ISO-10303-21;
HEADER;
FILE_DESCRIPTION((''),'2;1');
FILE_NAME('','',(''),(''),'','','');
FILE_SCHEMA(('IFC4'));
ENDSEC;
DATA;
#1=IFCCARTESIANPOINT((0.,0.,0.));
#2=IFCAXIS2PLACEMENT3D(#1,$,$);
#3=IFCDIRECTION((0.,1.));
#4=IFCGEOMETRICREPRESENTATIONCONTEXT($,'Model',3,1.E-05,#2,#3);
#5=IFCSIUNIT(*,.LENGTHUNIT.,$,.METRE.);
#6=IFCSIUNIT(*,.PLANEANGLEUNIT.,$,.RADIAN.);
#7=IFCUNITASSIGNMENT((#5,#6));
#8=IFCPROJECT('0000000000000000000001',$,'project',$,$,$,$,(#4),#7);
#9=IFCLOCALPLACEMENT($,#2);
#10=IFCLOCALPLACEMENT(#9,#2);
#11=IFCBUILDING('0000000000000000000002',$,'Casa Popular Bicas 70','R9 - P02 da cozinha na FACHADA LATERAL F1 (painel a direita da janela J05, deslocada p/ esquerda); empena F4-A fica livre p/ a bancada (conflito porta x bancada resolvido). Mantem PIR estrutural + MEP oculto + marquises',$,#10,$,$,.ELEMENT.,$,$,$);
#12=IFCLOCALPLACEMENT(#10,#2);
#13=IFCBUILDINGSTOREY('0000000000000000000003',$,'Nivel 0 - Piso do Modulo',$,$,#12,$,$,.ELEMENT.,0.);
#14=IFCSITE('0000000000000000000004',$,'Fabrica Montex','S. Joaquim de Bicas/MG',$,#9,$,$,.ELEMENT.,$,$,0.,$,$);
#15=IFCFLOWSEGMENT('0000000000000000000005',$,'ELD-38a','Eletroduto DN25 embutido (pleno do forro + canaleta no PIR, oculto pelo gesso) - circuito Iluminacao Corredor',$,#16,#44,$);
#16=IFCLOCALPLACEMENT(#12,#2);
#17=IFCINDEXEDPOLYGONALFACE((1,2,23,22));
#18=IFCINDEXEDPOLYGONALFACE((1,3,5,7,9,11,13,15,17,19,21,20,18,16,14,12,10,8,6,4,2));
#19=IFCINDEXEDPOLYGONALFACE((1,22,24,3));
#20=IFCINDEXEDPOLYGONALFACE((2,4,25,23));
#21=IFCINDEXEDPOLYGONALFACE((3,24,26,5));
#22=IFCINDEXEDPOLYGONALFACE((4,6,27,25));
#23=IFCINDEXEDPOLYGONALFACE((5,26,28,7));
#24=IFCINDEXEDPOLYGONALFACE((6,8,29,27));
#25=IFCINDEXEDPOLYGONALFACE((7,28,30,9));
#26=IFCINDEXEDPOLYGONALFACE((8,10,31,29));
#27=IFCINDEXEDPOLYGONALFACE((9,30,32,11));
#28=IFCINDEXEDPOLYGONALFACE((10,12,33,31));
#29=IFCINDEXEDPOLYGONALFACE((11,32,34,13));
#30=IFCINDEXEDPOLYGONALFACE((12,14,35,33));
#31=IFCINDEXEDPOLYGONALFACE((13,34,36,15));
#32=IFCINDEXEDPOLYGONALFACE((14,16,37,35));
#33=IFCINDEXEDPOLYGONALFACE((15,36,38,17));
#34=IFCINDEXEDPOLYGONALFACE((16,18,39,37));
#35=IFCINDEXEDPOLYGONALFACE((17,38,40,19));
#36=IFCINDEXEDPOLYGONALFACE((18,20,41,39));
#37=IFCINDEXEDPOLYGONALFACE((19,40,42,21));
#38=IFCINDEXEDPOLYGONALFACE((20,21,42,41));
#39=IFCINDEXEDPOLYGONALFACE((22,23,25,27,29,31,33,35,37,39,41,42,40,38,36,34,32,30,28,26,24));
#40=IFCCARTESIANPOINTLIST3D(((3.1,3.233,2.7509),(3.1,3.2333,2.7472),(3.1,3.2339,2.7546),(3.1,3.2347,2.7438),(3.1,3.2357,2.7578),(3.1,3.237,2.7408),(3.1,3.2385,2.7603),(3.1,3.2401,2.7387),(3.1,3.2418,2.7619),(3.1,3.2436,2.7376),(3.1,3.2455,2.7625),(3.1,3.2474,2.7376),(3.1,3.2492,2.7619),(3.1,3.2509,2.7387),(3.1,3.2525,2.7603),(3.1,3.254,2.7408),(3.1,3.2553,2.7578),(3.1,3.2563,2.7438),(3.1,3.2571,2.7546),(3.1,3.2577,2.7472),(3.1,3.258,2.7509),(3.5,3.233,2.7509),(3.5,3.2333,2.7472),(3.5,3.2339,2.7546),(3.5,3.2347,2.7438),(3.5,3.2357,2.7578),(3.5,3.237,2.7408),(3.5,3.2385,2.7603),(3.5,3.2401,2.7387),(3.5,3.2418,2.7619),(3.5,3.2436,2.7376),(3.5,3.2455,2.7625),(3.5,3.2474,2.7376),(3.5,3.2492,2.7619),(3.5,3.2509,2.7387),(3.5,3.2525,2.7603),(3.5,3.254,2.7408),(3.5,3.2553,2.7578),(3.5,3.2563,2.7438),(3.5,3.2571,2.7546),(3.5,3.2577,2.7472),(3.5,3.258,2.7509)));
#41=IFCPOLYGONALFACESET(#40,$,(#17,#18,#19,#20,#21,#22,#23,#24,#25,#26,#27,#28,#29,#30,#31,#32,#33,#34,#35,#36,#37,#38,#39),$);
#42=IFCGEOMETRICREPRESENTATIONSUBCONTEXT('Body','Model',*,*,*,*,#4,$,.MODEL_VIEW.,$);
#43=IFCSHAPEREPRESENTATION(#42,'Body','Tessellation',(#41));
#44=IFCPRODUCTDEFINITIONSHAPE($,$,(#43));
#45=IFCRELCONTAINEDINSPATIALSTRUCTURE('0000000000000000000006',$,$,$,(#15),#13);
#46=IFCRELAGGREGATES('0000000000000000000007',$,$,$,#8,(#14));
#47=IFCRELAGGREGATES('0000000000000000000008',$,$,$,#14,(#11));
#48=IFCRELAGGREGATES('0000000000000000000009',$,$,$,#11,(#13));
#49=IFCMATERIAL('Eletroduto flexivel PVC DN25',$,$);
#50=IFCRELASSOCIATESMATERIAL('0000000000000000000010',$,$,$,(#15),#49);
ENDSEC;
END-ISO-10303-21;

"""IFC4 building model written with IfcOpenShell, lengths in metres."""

from ifc_helpers import new_model, si_unit, direction, frame, origin, origin_2d, place, context, subcontext, project, spatial, circle, extrude, material, element, save


model = new_model("IFC4")

# Units and contexts
model_context_1 = context("Model", 3, precision=1e-05, world=origin(), true_north=direction((0.0, 1.0)))
body_context_1 = subcontext(model_context_1, "Body", "Model", "MODEL_VIEW")
ifc_project = project(units=[si_unit("LENGTHUNIT", "METRE"), si_unit("PLANEANGLEUNIT", "RADIAN")], contexts=[model_context_1])

# Site, building, storey
site_placement = place(None, origin())
site = spatial("IfcSite", under=ifc_project, at=site_placement, Name="Fabrica Montex", Description="S. Joaquim de Bicas/MG", CompositionType="ELEMENT", RefElevation=0.0)
building_placement = place(site_placement, origin())
building = spatial("IfcBuilding", under=site, at=building_placement, Name="Casa Popular Bicas 70", Description="R9 - P02 da cozinha na FACHADA LATERAL F1 (painel a direita da janela J05, deslocada p/ esquerda); empena F4-A fica livre p/ a bancada (conflito porta x bancada resolvido). Mantem PIR estrutural + MEP oculto + marquises", CompositionType="ELEMENT")
storey_placement = place(building_placement, origin())
storey = spatial("IfcBuildingStorey", under=building, at=storey_placement, Name="Nivel 0 - Piso do Modulo", CompositionType="ELEMENT", Elevation=0.0)

# Flow segment
ifc_material_1 = material(Name="Eletroduto flexivel PVC DN25")
flow_segment_1_placement = place(storey_placement, frame((3.5, 3.2455, 2.75), z_axis=(-1.0, 0.0, 0.0), x_axis=(0.0, 0.0, 1.0)))
element("IfcFlowSegment", 1, at=flow_segment_1_placement, inside=storey, material=ifc_material_1, Name="ELD-38a", Description="Eletroduto DN25 embutido (pleno do forro + canaleta no PIR, oculto pelo gesso) - circuito Iluminacao Corredor", context=body_context_1, shape_type="SweptSolid", body=[
    extrude(circle(Radius=0.0125, at=origin_2d()), origin(), (0.0, 0.0, 1.0), 0.4),
])

save(model, "model.ifc")
